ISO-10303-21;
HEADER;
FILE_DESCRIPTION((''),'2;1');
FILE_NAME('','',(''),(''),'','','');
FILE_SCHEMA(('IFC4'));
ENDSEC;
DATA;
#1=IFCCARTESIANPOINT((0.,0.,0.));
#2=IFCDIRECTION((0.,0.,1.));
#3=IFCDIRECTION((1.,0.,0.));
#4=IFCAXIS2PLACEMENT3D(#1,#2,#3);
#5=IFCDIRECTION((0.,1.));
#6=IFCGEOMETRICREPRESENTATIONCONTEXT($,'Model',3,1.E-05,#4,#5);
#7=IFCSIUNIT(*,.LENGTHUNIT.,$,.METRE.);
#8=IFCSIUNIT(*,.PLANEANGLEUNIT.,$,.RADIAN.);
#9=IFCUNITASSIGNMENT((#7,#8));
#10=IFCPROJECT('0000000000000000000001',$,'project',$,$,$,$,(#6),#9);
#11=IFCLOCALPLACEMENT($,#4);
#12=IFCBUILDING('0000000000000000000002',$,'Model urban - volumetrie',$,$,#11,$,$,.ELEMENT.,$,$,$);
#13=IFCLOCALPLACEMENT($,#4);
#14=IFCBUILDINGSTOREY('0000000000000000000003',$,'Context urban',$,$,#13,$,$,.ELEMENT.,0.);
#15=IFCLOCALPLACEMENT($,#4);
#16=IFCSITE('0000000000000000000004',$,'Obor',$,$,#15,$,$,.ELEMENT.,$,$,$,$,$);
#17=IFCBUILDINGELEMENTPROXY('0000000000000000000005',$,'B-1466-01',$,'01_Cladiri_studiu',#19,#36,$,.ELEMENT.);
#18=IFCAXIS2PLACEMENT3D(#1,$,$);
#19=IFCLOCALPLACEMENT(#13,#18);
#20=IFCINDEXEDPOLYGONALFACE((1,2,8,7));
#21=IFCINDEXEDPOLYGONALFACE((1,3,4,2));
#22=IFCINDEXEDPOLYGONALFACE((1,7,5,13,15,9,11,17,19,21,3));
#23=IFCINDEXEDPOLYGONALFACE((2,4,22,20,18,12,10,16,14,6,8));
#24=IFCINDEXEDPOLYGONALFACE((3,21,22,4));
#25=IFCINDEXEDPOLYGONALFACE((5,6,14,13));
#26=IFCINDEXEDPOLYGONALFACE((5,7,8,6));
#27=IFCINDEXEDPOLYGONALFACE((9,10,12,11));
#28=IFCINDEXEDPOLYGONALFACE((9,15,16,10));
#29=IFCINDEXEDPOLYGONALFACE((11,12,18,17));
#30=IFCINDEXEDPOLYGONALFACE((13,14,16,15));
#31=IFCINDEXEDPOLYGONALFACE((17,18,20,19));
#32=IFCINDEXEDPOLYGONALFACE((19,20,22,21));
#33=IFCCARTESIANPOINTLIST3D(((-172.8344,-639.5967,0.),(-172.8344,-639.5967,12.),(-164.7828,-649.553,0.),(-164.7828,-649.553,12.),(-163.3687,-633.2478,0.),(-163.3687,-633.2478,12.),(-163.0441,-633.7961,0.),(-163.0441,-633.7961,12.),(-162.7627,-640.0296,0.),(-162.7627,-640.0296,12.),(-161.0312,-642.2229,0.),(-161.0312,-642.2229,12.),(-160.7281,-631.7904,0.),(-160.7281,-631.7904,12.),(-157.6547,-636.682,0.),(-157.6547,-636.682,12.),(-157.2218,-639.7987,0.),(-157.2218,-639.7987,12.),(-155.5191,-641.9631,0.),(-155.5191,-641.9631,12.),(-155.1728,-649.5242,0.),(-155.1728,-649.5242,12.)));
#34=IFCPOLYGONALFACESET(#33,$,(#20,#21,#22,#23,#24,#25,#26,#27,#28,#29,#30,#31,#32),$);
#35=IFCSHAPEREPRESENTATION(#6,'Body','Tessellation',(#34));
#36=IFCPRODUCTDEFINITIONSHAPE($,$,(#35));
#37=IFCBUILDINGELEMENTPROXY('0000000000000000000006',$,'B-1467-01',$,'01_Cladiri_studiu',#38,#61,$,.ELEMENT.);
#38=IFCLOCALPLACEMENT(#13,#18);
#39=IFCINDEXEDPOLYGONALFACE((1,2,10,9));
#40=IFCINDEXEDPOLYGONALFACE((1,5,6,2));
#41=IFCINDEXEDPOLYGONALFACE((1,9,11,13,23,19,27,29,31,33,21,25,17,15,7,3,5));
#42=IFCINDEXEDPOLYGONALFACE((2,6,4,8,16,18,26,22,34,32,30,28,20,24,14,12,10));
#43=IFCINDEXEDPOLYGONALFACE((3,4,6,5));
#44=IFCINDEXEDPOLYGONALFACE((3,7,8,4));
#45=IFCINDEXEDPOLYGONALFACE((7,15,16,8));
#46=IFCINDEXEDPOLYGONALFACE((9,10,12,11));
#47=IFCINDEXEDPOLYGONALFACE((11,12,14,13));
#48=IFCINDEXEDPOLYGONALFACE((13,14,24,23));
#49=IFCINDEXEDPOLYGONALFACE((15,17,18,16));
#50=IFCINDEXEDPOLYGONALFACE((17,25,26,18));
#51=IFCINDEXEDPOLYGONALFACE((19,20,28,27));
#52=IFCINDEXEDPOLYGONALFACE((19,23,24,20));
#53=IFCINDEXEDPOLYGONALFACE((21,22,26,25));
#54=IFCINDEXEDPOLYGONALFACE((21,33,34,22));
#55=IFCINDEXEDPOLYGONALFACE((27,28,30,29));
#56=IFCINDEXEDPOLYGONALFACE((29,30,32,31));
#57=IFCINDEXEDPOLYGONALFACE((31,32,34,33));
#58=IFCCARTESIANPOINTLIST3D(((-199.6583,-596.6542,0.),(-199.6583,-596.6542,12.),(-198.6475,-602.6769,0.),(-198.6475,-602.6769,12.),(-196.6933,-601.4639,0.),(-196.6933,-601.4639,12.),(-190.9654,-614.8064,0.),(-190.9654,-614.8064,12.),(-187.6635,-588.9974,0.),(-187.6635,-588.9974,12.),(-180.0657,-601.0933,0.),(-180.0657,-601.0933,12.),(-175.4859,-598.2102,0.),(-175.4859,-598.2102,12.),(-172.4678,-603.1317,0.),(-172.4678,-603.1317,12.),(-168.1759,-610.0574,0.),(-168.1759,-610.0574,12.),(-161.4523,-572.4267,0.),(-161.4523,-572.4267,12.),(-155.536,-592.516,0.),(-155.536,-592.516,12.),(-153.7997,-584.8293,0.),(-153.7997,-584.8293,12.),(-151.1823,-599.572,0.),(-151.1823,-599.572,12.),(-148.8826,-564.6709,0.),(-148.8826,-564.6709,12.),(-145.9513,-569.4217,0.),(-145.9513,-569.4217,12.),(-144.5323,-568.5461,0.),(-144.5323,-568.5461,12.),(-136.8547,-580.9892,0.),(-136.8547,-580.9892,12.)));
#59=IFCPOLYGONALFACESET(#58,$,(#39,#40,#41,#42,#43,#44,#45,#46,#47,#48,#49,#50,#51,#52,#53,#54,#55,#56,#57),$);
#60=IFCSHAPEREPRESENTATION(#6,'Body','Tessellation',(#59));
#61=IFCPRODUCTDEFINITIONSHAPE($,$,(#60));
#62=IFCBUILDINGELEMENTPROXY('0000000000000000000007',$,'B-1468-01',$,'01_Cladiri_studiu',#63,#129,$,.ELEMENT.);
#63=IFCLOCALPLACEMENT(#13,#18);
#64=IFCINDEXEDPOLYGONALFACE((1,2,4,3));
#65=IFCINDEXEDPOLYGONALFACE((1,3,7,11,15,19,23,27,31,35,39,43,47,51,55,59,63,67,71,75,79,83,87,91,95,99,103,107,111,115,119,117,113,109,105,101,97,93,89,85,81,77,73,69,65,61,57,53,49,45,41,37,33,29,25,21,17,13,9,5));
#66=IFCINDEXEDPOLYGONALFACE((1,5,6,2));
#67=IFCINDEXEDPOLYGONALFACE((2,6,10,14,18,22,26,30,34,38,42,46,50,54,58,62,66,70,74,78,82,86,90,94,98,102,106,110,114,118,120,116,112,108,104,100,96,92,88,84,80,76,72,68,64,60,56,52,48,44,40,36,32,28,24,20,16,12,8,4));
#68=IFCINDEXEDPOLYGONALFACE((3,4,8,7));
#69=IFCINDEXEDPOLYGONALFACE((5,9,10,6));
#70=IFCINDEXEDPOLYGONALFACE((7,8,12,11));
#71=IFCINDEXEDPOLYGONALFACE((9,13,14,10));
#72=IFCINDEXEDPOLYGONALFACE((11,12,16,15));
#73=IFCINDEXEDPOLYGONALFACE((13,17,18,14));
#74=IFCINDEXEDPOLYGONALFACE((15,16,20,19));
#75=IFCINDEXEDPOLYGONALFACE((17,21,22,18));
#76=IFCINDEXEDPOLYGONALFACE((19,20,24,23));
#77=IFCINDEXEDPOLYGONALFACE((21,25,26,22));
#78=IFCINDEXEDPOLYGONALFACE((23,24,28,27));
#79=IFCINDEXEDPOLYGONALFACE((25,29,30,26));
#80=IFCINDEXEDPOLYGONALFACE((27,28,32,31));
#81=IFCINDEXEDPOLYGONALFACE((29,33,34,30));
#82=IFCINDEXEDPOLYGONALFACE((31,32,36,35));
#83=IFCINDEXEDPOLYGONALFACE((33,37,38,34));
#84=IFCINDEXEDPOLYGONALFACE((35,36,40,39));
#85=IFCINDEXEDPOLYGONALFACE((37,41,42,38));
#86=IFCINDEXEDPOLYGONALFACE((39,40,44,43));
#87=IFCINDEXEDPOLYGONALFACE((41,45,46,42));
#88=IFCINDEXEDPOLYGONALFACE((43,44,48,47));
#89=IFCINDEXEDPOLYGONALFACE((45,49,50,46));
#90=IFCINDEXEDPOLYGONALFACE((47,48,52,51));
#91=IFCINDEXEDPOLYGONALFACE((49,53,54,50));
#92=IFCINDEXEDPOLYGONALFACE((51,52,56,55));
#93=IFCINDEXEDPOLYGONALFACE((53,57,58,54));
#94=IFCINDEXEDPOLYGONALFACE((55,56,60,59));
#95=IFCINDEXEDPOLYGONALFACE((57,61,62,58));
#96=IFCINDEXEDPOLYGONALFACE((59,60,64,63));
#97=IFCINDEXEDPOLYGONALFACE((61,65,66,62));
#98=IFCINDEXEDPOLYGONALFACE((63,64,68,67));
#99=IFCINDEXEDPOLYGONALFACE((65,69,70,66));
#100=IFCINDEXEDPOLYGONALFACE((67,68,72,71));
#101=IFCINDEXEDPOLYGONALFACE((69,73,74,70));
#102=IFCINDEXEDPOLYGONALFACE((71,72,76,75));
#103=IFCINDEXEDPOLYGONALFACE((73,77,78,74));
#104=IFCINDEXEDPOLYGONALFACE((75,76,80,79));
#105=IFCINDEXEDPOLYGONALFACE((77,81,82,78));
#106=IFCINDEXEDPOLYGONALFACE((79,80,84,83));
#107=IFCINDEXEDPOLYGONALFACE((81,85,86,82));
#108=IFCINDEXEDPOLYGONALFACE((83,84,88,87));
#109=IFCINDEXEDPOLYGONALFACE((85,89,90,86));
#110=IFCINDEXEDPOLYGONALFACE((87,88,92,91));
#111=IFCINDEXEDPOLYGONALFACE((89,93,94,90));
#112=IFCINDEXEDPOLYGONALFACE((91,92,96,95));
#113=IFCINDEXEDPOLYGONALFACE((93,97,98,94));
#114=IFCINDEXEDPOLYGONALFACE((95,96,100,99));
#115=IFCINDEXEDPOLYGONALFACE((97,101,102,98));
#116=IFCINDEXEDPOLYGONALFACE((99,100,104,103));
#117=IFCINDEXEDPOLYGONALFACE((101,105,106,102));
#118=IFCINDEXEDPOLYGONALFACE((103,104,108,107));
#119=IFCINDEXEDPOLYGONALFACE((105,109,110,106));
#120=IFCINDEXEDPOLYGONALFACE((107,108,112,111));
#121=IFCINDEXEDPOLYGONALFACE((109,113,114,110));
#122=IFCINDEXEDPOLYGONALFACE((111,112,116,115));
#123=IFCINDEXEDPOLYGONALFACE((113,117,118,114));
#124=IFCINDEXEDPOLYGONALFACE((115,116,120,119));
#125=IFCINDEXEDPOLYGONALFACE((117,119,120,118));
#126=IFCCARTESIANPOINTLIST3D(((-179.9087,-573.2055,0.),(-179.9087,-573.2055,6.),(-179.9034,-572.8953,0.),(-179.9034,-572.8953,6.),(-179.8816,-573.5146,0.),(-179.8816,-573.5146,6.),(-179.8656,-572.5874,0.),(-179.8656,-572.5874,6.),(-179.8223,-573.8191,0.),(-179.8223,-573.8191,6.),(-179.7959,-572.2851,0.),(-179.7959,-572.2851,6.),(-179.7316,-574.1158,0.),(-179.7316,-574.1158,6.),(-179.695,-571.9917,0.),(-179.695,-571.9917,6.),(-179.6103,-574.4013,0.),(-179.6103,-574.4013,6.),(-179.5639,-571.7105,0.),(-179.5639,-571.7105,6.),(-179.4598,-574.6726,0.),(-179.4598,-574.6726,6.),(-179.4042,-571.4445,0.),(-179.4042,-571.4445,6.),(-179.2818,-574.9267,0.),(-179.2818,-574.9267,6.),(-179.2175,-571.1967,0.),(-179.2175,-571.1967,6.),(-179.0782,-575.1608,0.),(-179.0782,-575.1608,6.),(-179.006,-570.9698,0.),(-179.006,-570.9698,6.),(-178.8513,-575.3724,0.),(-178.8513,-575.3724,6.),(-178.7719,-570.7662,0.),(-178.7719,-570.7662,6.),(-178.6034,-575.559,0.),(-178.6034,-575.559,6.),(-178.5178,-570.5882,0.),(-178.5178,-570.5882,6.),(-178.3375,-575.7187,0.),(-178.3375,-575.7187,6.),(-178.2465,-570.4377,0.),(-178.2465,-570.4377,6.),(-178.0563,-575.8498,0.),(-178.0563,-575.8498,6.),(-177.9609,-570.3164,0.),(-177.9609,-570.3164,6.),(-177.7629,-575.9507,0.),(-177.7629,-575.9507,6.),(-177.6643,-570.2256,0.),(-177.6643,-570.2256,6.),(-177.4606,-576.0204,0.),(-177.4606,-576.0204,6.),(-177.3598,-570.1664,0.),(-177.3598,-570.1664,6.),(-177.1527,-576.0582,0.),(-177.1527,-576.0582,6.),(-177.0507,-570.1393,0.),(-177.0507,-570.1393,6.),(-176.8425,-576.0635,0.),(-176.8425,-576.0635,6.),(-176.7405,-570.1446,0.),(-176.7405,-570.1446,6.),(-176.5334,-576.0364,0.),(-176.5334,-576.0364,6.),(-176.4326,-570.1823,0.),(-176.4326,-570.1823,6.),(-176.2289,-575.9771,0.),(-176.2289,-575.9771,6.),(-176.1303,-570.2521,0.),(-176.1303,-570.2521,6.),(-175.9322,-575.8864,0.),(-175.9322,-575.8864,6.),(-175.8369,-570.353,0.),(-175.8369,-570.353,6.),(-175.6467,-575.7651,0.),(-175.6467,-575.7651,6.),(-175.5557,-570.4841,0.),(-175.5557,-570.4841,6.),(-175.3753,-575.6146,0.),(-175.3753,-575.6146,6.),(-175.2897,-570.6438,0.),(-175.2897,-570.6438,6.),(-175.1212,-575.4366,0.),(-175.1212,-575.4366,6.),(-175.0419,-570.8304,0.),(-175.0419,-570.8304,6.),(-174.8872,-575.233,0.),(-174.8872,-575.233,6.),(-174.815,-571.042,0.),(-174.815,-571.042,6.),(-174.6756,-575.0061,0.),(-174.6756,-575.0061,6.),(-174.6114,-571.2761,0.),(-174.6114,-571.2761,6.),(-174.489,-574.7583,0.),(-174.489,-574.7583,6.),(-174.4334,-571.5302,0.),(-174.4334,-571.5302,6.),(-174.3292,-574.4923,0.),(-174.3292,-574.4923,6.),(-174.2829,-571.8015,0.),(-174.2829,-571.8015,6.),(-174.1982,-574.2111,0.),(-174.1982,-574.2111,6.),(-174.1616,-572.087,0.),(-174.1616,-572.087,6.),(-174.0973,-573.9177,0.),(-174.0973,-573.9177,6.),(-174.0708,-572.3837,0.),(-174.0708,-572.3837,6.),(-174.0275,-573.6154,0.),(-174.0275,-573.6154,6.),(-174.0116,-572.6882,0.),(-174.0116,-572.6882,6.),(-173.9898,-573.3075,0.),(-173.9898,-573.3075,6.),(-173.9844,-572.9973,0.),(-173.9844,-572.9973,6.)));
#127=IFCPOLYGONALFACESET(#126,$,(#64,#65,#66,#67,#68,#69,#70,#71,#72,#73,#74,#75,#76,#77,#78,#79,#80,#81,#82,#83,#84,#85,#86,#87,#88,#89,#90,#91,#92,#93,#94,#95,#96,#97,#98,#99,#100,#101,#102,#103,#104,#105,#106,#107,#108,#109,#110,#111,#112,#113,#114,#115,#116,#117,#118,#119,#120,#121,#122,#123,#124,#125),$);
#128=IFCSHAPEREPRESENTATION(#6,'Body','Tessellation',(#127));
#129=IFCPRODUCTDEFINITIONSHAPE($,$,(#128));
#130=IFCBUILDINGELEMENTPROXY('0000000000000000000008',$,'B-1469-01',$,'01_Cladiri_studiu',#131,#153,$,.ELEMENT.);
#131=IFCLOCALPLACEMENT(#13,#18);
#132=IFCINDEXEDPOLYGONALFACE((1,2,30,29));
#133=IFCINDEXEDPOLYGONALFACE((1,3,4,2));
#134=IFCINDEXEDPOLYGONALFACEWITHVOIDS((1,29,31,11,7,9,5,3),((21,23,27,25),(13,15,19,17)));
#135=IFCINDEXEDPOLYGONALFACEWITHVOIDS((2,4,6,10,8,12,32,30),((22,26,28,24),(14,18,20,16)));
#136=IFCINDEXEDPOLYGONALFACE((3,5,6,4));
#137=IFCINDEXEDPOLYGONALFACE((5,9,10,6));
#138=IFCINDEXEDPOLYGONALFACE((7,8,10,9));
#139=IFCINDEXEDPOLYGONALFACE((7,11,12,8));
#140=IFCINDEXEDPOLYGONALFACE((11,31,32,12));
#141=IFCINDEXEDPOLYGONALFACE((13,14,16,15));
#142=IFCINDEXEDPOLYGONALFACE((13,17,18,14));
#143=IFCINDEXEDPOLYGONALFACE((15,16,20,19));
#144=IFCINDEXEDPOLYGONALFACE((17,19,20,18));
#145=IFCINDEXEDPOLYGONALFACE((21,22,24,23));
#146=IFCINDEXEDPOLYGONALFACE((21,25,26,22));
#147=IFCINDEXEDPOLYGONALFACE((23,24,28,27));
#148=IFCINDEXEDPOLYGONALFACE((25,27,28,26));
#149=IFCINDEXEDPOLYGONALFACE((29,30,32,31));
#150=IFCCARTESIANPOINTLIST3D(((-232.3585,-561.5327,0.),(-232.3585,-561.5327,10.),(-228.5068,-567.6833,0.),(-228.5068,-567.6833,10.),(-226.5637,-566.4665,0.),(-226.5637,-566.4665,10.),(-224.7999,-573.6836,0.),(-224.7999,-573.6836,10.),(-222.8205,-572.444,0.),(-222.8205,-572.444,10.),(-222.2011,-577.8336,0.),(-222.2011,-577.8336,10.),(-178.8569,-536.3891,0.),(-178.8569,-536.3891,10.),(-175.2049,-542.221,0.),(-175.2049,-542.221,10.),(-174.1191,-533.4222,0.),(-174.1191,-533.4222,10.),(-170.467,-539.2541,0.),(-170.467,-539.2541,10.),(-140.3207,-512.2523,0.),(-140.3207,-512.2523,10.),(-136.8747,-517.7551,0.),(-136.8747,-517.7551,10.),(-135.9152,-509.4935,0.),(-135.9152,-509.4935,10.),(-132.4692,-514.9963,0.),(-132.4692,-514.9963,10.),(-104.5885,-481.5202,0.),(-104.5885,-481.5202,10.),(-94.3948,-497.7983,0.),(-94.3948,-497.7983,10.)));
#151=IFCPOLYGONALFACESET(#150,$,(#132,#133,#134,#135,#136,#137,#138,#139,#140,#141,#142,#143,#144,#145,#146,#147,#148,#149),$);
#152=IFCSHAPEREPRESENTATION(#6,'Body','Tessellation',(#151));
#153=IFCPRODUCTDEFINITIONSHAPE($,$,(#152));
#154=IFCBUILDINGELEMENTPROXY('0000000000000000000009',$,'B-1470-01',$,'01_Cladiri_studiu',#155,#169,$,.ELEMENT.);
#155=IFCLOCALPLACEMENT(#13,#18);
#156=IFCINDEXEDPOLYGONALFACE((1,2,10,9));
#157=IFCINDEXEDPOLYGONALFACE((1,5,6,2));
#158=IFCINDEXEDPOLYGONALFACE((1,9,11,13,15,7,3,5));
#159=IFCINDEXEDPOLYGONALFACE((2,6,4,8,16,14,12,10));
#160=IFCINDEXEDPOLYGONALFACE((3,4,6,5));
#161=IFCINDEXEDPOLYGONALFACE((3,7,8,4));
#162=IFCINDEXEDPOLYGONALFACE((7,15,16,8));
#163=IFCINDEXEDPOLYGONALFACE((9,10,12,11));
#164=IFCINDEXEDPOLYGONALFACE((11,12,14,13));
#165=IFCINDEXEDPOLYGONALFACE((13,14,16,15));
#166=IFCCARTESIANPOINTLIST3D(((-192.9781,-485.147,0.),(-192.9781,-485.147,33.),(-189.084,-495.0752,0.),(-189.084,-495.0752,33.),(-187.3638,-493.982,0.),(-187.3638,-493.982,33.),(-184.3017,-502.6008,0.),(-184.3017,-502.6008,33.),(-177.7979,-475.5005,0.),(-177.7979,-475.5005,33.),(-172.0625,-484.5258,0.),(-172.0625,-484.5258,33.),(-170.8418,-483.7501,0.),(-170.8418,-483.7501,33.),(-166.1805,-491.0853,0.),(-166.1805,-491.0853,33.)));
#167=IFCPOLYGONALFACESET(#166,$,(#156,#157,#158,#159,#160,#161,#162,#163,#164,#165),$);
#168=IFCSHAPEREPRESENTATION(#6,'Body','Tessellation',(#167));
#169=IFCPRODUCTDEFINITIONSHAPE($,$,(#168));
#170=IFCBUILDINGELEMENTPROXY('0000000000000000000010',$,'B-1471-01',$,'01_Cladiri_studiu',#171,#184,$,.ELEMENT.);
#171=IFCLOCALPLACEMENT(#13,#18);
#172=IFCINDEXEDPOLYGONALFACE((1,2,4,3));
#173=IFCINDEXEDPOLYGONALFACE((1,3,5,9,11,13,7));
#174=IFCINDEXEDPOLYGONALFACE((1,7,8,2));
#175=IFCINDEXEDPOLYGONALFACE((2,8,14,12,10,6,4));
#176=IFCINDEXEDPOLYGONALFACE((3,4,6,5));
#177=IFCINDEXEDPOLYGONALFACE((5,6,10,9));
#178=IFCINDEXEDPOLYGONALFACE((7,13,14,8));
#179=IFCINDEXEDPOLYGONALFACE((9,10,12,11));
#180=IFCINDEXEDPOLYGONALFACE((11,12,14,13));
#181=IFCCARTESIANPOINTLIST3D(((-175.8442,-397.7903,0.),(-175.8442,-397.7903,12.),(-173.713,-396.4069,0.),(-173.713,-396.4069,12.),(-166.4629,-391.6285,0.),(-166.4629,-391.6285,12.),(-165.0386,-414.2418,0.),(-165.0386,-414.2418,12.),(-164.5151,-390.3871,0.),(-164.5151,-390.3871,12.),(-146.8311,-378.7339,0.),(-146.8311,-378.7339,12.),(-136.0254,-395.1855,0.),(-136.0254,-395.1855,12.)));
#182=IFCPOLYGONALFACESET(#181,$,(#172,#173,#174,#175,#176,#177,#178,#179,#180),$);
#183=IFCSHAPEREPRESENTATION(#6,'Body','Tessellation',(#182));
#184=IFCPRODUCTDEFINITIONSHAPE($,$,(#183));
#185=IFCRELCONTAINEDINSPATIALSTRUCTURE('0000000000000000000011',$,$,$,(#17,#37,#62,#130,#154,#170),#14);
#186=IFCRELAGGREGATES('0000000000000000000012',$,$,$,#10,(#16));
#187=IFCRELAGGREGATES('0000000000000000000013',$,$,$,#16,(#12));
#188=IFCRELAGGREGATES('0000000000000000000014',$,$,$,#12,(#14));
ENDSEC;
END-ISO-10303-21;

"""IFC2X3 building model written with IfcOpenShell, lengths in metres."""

from ifc_helpers import new_model, si_unit, direction, origin_with_axes, place, context, project, spatial, polyline, outline, extrude, element, save


model = new_model("IFC2X3")

# Units and contexts
model_context = context("Model", 3, precision=1e-05, world=origin_with_axes(), true_north=direction((0.0, 1.0)))
ifc_project = project(units=[si_unit("LENGTHUNIT", "METRE"), si_unit("PLANEANGLEUNIT", "RADIAN")], contexts=[model_context])

# Site, building, storey
site_placement = place(None, origin_with_axes())
site = spatial("IfcSite", under=ifc_project, at=site_placement, Name="Obor", CompositionType="ELEMENT")
building_placement = place(None, origin_with_axes())
building = spatial("IfcBuilding", under=site, at=building_placement, Name="Model urban - volumetrie", CompositionType="ELEMENT")
storey_placement = place(None, origin_with_axes())
storey = spatial("IfcBuildingStorey", under=building, at=storey_placement, Name="Context urban", CompositionType="ELEMENT", Elevation=0.0)

# Building element proxies
proxy_1_placement = place(None, origin_with_axes())
element("IfcBuildingElementProxy", 1, at=proxy_1_placement, inside=storey, Name="B-1466-01", ObjectType="01_Cladiri_studiu", CompositionType="ELEMENT", context=model_context, shape_type="SweptSolid", body=[
    extrude(outline(polyline([(-161.0312, -642.2229), (-162.7627, -640.0296), (-157.6547, -636.682), (-160.7281, -631.7904), (-163.3687, -633.2478), (-163.0441, -633.7961), (-172.8344, -639.5967), (-164.7828, -649.553), (-155.1728, -649.5242), (-155.5191, -641.9631), (-157.2218, -639.7987), (-161.0312, -642.2229)])), origin_with_axes(), (0.0, 0.0, 1.0), 12.0),
])
proxy_2_placement = place(None, origin_with_axes())
element("IfcBuildingElementProxy", 2, at=proxy_2_placement, inside=storey, Name="B-1467-01", ObjectType="01_Cladiri_studiu", CompositionType="ELEMENT", context=model_context, shape_type="SweptSolid", body=[
    extrude(outline(polyline([(-196.6933, -601.4639), (-198.6475, -602.6769), (-190.9654, -614.8064), (-172.4678, -603.1317), (-168.1759, -610.0574), (-151.1823, -599.572), (-155.536, -592.516), (-136.8547, -580.9892), (-144.5323, -568.5461), (-145.9513, -569.4217), (-148.8826, -564.6709), (-161.4523, -572.4267), (-153.7997, -584.8293), (-175.4859, -598.2102), (-180.0657, -601.0933), (-187.6635, -588.9974), (-199.6583, -596.6542), (-196.6933, -601.4639)])), origin_with_axes(), (0.0, 0.0, 1.0), 12.0),
])
proxy_3_placement = place(None, origin_with_axes())
element("IfcBuildingElementProxy", 3, at=proxy_3_placement, inside=storey, Name="B-1468-01", ObjectType="01_Cladiri_studiu", CompositionType="ELEMENT", context=model_context, shape_type="SweptSolid", body=[
    extrude(outline(polyline([(-178.6034, -575.559), (-178.3375, -575.7187), (-178.0563, -575.8498), (-177.7629, -575.9507), (-177.4606, -576.0204), (-177.1527, -576.0582), (-176.8425, -576.0635), (-176.5334, -576.0364), (-176.2289, -575.9771), (-175.9322, -575.8864), (-175.6467, -575.7651), (-175.3753, -575.6146), (-175.1212, -575.4366), (-174.8872, -575.233), (-174.6756, -575.0061), (-174.489, -574.7583), (-174.3292, -574.4923), (-174.1982, -574.2111), (-174.0973, -573.9177), (-174.0275, -573.6154), (-173.9898, -573.3075), (-173.9844, -572.9973), (-174.0116, -572.6882), (-174.0708, -572.3837), (-174.1616, -572.087), (-174.2829, -571.8015), (-174.4334, -571.5302), (-174.6114, -571.2761), (-174.815, -571.042), (-175.0419, -570.8304), (-175.2897, -570.6438), (-175.5557, -570.4841), (-175.8369, -570.353), (-176.1303, -570.2521), (-176.4326, -570.1823), (-176.7405, -570.1446), (-177.0507, -570.1393), (-177.3598, -570.1664), (-177.6643, -570.2256), (-177.9609, -570.3164), (-178.2465, -570.4377), (-178.5178, -570.5882), (-178.7719, -570.7662), (-179.006, -570.9698), (-179.2175, -571.1967), (-179.4042, -571.4445), (-179.5639, -571.7105), (-179.695, -571.9917), (-179.7959, -572.2851), (-179.8656, -572.5874), (-179.9034, -572.8953), (-179.9087, -573.2055), (-179.8816, -573.5146), (-179.8223, -573.8191), (-179.7316, -574.1158), (-179.6103, -574.4013), (-179.4598, -574.6726), (-179.2818, -574.9267), (-179.0782, -575.1608), (-178.8513, -575.3724), (-178.6034, -575.559)])), origin_with_axes(), (0.0, 0.0, 1.0), 6.0),
])
proxy_4_placement = place(None, origin_with_axes())
element("IfcBuildingElementProxy", 4, at=proxy_4_placement, inside=storey, Name="B-1469-01", ObjectType="01_Cladiri_studiu", CompositionType="ELEMENT", context=model_context, shape_type="SweptSolid", body=[
    extrude(outline(polyline([(-222.2011, -577.8336), (-94.3948, -497.7983), (-104.5885, -481.5202), (-232.3585, -561.5327), (-228.5068, -567.6833), (-226.5637, -566.4665), (-222.8205, -572.444), (-224.7999, -573.6836), (-222.2011, -577.8336)]), holes=[polyline([(-140.3207, -512.2523), (-135.9152, -509.4935), (-132.4692, -514.9963), (-136.8747, -517.7551), (-140.3207, -512.2523)]), polyline([(-178.8569, -536.3891), (-174.1191, -533.4222), (-170.467, -539.2541), (-175.2049, -542.221), (-178.8569, -536.3891)])]), origin_with_axes(), (0.0, 0.0, 1.0), 10.0),
])
proxy_5_placement = place(None, origin_with_axes())
element("IfcBuildingElementProxy", 5, at=proxy_5_placement, inside=storey, Name="B-1470-01", ObjectType="01_Cladiri_studiu", CompositionType="ELEMENT", context=model_context, shape_type="SweptSolid", body=[
    extrude(outline(polyline([(-189.084, -495.0752), (-184.3017, -502.6008), (-166.1805, -491.0853), (-170.8418, -483.7501), (-172.0625, -484.5258), (-177.7979, -475.5005), (-192.9781, -485.147), (-187.3638, -493.982), (-189.084, -495.0752)])), origin_with_axes(), (0.0, 0.0, 1.0), 33.0),
])
proxy_6_placement = place(None, origin_with_axes())
element("IfcBuildingElementProxy", 6, at=proxy_6_placement, inside=storey, Name="B-1471-01", ObjectType="01_Cladiri_studiu", CompositionType="ELEMENT", context=model_context, shape_type="SweptSolid", body=[
    extrude(outline(polyline([(-146.8311, -378.7339), (-164.5151, -390.3871), (-166.4629, -391.6285), (-173.713, -396.4069), (-175.8442, -397.7903), (-165.0386, -414.2418), (-136.0254, -395.1855), (-146.8311, -378.7339)])), origin_with_axes(), (0.0, 0.0, 1.0), 12.0),
])

save(model, "model.ifc")
